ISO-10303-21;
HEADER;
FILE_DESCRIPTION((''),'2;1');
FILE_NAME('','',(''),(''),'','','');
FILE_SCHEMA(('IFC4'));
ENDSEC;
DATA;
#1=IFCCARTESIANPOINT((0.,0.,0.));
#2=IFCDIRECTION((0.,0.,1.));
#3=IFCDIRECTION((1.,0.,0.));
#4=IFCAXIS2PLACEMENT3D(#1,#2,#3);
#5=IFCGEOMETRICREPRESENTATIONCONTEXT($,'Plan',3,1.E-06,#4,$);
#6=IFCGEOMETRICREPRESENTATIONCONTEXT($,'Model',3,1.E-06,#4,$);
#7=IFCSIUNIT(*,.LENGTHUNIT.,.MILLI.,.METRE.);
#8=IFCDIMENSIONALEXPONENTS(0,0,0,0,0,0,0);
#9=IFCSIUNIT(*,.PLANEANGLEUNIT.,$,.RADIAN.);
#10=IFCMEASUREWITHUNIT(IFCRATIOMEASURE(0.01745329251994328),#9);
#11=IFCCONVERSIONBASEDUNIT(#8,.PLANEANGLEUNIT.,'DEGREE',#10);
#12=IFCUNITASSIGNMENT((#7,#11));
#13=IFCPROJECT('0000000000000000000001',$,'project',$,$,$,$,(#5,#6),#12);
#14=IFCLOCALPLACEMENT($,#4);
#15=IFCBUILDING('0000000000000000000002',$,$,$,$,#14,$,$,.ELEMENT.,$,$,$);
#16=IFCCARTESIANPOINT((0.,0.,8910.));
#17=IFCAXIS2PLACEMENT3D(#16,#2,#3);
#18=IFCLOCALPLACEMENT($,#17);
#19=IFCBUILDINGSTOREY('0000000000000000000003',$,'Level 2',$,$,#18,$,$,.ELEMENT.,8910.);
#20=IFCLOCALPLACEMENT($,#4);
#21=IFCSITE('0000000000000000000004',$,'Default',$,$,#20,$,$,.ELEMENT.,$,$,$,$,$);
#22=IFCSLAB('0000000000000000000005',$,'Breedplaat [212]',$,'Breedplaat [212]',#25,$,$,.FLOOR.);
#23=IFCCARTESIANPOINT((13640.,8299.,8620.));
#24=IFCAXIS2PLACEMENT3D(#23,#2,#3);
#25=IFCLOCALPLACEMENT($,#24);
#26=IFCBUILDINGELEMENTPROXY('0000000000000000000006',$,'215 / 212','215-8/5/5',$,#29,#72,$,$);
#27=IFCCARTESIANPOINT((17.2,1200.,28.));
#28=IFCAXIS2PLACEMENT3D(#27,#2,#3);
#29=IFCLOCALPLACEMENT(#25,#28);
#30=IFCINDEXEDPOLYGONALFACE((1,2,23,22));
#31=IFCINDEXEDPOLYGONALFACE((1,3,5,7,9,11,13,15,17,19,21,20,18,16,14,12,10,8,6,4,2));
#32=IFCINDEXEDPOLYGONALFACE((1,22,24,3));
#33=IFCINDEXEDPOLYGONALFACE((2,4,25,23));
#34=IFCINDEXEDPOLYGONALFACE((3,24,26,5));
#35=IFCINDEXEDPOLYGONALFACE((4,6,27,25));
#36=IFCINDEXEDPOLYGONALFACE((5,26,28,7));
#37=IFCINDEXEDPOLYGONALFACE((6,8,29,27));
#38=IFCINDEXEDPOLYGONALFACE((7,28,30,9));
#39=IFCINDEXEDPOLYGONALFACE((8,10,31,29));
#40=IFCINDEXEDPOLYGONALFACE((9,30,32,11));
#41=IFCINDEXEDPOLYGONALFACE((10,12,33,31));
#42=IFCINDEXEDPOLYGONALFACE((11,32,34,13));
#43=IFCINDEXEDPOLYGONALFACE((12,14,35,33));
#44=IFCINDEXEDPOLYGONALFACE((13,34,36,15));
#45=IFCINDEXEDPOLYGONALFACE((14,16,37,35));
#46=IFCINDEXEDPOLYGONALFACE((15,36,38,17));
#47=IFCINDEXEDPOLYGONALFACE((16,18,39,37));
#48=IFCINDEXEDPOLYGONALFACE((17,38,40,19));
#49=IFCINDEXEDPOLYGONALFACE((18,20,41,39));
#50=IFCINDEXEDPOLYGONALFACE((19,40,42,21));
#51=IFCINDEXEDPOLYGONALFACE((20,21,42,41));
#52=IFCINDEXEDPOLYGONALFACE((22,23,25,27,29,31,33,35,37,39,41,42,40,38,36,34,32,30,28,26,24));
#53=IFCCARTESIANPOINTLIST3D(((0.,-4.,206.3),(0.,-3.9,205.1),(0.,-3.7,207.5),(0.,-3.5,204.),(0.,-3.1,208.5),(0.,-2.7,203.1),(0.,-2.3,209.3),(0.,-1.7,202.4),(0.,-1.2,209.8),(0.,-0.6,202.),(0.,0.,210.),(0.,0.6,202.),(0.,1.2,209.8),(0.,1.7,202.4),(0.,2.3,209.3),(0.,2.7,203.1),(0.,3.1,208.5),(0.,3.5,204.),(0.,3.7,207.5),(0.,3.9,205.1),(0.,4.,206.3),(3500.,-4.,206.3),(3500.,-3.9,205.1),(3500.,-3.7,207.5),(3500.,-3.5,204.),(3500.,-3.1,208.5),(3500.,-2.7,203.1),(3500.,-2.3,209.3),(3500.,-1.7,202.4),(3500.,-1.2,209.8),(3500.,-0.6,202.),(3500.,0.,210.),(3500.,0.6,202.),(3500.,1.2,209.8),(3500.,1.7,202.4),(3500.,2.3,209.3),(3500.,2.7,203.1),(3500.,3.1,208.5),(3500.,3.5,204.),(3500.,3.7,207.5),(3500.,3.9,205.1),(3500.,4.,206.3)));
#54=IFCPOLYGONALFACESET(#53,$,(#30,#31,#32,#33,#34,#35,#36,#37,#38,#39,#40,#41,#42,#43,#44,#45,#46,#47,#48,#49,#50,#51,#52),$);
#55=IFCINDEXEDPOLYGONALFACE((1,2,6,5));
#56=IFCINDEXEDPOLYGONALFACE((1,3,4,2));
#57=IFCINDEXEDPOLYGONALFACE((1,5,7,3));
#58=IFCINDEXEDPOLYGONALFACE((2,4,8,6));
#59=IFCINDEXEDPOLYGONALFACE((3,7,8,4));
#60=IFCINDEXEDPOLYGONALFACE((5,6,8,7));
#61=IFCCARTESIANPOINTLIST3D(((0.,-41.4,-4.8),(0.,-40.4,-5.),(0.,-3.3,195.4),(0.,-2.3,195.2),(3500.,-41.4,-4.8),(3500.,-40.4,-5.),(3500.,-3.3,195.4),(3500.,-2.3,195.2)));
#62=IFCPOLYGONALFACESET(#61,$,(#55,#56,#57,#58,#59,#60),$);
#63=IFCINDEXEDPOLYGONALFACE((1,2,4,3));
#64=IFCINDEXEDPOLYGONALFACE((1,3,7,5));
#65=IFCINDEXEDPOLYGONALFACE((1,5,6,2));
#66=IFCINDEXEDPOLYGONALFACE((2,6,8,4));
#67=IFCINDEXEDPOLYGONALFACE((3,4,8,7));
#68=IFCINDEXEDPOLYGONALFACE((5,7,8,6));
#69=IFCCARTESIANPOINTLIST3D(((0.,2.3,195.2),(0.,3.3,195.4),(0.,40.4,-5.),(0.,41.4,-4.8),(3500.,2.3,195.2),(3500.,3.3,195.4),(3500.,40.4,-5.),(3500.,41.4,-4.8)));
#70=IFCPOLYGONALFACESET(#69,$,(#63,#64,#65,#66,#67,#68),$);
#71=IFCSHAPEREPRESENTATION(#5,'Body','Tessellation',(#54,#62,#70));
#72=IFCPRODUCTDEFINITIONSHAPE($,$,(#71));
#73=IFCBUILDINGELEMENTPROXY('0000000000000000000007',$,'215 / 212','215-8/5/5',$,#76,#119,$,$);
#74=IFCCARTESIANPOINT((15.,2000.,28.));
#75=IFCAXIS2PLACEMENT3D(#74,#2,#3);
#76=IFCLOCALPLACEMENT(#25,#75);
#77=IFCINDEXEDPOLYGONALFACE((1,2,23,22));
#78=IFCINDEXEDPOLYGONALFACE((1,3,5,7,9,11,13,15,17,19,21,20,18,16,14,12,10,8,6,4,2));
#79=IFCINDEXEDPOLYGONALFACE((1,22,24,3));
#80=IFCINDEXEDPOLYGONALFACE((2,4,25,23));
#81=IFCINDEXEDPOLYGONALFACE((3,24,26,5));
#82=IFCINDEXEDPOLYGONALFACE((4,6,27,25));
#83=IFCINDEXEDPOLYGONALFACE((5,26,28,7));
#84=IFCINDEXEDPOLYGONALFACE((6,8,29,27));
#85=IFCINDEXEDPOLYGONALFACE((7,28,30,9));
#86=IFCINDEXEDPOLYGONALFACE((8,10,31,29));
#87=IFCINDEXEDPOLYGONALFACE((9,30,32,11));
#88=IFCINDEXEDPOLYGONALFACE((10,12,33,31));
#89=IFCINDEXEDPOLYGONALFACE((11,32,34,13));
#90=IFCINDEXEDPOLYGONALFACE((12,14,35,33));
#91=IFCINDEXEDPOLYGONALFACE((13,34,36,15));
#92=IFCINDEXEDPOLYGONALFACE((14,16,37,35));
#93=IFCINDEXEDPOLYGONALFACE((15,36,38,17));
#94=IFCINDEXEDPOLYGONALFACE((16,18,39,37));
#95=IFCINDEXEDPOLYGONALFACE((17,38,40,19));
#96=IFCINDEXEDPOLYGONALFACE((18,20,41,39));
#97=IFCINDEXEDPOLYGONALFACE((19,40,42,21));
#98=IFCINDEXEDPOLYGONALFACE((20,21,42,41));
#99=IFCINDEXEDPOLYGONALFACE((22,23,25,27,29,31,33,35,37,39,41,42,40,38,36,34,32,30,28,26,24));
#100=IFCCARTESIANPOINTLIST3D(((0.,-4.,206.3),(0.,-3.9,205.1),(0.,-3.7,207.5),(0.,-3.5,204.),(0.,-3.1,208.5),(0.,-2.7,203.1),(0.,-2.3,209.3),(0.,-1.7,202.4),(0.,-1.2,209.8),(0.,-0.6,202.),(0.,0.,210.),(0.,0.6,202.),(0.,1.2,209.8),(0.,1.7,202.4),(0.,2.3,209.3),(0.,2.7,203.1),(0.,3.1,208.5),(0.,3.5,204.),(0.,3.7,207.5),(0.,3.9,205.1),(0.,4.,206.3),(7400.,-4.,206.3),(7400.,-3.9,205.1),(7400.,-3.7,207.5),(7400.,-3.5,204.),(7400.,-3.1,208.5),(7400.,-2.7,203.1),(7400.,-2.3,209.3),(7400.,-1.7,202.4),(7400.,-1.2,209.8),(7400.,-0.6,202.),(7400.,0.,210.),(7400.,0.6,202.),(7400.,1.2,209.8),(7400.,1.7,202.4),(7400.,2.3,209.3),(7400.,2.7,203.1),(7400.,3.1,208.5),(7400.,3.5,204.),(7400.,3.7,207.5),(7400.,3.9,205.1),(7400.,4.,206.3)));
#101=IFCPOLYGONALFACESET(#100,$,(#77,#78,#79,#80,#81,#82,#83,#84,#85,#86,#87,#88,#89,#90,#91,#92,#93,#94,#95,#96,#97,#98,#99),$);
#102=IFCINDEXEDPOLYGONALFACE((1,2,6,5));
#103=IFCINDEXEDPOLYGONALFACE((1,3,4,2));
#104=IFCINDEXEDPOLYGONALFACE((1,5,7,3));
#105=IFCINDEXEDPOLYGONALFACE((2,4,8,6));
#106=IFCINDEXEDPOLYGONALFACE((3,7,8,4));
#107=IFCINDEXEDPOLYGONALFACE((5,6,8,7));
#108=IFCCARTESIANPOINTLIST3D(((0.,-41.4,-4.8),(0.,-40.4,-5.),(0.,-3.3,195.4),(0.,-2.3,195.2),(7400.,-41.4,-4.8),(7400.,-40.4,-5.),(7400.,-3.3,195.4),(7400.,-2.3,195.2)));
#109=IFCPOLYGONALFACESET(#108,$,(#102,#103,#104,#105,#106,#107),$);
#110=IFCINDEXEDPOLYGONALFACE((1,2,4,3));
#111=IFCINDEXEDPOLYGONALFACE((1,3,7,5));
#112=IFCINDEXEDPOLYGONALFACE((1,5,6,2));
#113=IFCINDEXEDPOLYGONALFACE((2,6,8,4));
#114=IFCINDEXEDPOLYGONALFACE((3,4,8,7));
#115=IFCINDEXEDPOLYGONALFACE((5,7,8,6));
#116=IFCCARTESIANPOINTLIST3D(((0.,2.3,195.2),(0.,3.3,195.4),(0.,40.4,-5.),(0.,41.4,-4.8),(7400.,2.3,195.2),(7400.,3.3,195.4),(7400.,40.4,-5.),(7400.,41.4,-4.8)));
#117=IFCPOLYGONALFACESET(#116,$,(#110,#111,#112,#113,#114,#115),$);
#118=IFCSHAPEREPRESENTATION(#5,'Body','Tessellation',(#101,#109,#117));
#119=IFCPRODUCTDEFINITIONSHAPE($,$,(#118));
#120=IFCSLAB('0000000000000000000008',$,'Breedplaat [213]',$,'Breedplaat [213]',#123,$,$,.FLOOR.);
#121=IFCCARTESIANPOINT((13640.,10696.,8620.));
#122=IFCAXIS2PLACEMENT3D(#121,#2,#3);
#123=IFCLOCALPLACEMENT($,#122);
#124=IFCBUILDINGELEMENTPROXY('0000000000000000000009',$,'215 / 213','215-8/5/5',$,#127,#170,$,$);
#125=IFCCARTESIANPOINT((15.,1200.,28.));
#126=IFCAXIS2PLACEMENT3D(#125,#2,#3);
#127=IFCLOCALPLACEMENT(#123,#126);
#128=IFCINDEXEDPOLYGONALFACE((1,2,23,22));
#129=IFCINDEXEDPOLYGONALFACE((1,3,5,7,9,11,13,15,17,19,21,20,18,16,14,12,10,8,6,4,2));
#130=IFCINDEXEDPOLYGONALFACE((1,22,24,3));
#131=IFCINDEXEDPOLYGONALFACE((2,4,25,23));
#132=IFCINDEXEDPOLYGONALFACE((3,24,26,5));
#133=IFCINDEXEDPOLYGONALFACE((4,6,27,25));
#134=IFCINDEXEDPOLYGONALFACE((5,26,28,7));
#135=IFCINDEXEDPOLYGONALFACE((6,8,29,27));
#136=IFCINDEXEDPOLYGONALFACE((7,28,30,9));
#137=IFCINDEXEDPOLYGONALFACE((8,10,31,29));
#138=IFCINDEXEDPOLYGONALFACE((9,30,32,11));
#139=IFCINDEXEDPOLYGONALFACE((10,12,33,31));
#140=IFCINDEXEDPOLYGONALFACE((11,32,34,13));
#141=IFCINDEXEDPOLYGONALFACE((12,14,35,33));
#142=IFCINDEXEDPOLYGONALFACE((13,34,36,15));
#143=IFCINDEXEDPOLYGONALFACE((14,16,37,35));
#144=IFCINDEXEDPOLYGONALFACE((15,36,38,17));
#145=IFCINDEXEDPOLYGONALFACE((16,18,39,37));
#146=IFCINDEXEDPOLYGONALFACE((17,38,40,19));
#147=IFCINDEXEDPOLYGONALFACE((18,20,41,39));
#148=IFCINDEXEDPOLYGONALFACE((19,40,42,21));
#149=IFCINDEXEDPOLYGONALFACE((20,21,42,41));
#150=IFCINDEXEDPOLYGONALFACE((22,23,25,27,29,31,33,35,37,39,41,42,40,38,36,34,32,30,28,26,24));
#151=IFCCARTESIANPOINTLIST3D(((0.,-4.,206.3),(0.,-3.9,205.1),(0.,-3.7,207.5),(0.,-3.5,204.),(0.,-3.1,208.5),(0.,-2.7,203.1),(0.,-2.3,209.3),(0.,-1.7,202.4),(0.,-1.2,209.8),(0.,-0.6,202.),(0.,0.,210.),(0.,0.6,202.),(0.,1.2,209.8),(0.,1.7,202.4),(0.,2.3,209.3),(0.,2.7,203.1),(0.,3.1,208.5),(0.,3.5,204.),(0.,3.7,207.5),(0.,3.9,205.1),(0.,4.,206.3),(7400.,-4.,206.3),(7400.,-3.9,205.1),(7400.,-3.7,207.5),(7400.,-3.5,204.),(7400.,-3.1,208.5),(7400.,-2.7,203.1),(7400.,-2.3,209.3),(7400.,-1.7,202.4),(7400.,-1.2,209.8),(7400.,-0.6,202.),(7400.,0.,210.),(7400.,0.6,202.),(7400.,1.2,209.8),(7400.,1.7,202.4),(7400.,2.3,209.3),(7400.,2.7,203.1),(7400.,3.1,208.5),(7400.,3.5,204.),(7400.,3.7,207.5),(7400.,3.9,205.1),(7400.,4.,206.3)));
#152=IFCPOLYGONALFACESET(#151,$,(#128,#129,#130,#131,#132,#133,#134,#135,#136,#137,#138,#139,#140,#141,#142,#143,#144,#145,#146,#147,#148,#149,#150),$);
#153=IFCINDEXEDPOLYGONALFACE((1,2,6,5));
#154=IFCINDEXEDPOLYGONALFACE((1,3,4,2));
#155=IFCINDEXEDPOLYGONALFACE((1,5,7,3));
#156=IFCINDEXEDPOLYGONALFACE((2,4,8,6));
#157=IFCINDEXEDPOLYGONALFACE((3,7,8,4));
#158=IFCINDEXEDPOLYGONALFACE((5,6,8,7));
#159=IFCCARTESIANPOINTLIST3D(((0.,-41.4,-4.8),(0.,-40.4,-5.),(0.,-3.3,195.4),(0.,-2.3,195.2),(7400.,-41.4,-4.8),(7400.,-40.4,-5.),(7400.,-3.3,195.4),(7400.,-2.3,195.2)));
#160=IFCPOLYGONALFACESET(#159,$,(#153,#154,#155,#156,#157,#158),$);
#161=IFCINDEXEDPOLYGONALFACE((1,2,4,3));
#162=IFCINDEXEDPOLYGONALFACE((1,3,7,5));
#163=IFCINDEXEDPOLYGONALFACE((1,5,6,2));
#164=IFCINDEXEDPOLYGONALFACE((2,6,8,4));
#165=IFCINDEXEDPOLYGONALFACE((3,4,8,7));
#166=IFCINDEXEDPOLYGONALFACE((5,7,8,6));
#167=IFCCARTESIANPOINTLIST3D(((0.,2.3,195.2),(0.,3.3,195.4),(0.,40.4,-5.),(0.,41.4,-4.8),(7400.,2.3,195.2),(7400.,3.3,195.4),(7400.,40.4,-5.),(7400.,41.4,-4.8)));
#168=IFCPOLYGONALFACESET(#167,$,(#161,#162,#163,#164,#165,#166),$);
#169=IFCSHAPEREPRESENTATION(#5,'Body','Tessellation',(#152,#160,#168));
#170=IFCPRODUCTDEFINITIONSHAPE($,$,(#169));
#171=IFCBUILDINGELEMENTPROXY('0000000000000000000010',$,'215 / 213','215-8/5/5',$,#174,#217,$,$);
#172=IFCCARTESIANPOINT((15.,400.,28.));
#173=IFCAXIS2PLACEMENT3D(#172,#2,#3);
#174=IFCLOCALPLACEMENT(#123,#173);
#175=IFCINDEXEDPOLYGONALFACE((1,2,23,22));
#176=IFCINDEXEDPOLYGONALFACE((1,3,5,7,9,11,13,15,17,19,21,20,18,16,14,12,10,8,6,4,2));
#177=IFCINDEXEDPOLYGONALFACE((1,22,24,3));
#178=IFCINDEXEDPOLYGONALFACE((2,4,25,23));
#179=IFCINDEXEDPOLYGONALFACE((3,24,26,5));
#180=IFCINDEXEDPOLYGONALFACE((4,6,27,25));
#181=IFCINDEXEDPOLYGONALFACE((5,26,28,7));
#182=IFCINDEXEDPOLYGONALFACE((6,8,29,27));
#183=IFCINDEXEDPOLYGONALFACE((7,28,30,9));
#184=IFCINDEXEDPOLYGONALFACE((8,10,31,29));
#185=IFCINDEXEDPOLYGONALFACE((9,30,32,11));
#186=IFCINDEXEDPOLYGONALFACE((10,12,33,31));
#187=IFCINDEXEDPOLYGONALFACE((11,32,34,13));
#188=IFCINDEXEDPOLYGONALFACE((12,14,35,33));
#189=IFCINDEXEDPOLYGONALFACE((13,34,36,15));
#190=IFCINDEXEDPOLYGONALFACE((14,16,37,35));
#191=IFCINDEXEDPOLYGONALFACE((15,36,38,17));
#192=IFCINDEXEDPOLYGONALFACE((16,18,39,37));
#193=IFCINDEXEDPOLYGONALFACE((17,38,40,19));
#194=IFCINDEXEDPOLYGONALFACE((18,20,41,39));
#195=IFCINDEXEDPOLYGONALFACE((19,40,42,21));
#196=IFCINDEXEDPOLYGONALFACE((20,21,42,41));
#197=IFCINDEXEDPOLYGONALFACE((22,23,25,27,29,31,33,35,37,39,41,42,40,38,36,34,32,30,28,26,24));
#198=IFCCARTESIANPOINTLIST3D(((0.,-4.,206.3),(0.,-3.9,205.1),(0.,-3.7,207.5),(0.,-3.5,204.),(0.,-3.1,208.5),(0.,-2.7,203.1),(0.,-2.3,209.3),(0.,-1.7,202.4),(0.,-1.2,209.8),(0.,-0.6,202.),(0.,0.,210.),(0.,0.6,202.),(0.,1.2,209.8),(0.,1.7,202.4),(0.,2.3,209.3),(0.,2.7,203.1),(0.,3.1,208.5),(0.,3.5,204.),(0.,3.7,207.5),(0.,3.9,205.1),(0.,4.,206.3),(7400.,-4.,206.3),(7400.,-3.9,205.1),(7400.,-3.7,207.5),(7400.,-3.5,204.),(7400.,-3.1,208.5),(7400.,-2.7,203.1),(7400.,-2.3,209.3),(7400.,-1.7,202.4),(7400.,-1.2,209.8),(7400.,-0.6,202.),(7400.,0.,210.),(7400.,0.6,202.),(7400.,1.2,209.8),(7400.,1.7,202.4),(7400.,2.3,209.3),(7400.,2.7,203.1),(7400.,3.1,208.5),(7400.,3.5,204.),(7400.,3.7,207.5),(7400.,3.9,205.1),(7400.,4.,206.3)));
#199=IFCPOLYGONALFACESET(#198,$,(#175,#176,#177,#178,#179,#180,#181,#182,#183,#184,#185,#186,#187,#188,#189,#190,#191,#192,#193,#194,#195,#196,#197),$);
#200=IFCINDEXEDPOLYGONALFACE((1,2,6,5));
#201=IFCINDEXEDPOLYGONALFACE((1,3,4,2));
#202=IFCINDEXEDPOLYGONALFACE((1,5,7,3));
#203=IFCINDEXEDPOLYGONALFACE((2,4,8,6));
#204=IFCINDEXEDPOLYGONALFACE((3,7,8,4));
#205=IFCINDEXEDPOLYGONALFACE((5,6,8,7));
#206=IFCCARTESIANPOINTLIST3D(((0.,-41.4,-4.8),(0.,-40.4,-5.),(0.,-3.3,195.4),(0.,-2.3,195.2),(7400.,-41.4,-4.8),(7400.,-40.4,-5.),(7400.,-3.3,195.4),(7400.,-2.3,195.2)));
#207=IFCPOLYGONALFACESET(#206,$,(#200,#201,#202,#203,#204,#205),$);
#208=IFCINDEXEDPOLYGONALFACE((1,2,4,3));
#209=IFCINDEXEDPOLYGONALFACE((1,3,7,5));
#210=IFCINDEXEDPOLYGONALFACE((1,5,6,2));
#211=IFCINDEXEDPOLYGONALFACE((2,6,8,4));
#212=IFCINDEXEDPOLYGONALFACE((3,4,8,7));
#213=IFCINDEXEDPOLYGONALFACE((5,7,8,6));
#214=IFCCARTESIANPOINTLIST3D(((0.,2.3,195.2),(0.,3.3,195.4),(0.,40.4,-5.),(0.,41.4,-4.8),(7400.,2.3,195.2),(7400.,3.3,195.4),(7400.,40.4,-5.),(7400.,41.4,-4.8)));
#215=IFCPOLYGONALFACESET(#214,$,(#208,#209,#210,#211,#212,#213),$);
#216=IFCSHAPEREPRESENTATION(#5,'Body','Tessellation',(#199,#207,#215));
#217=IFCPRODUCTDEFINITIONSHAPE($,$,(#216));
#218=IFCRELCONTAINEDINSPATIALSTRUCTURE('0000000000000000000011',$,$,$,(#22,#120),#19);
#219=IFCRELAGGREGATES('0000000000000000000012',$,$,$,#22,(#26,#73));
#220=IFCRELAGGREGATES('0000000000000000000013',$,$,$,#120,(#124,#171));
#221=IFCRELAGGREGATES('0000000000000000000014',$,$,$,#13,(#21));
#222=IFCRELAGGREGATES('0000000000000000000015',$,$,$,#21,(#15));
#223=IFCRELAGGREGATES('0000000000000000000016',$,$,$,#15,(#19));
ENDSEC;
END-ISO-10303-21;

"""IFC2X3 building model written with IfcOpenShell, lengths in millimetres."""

from ifc_helpers import new_model, entity, si_unit, converted_unit, frame, origin_with_axes, origin_2d_with_axis, place, context, project, spatial, rectangle, circle, extrude, element, aggregate, save


model = new_model("IFC2X3")

# Units and contexts
plan_context = context("Plan", 3, precision=1e-06, world=origin_with_axes())
model_context = context("Model", 3, precision=1e-06, world=origin_with_axes())
ifc_project = project(units=[si_unit("LENGTHUNIT", "METRE", prefix="MILLI"), converted_unit("PLANEANGLEUNIT", "DEGREE", entity("IfcRatioMeasure", 0.01745329251994328), si_unit("PLANEANGLEUNIT", "RADIAN"), dimensions=[0, 0, 0, 0, 0, 0, 0])], contexts=[plan_context, model_context])

# Site, building, storey
site_placement = place(None, origin_with_axes())
site = spatial("IfcSite", under=ifc_project, at=site_placement, Name="Default", CompositionType="ELEMENT")
building_placement = place(None, origin_with_axes())
building = spatial("IfcBuilding", under=site, at=building_placement, CompositionType="ELEMENT")
storey_placement = place(None, frame((0.0, 0.0, 8910.0), z_axis=(0.0, 0.0, 1.0), x_axis=(1.0, 0.0, 0.0)))
storey = spatial("IfcBuildingStorey", under=building, at=storey_placement, Name="Level 2", CompositionType="ELEMENT", Elevation=8910.0)

# Slab, building element proxies
slab_1_placement = place(None, frame((13640.0, 8299.0, 8620.0), z_axis=(0.0, 0.0, 1.0), x_axis=(1.0, 0.0, 0.0)))
slab_1 = element("IfcSlab", 1, at=slab_1_placement, inside=storey, Name="Breedplaat [212]", ObjectType="Breedplaat [212]", PredefinedType="FLOOR")
proxy_1_placement = place(slab_1_placement, frame((17.2, 1200.0, 28.0), z_axis=(0.0, 0.0, 1.0), x_axis=(1.0, 0.0, 0.0)))
proxy_1 = element("IfcBuildingElementProxy", 2, at=proxy_1_placement, Name="215 / 212", Description="215-8/5/5", context=plan_context, shape_type="SweptSolid", body=[
    extrude(circle(Radius=4.0, at=origin_2d_with_axis()), frame((0.0, 0.0, 206.0), z_axis=(1.0, 0.0, 0.0), x_axis=(0.0, 0.0, 1.0)), (0.0, 0.0, 1.0), 3500.0),
    extrude(rectangle(XDim=203.8, YDim=1.0, at=origin_2d_with_axis()), frame((0.0, -21.9, 95.2), z_axis=(1.0, 0.0, 0.0), x_axis=(0.0, 0.187112, 0.982339)), (0.0, 0.0, 1.0), 3500.0),
    extrude(rectangle(XDim=203.8, YDim=1.0, at=origin_2d_with_axis()), frame((0.0, 21.9, 95.2), z_axis=(1.0, 0.0, 0.0), x_axis=(0.0, -0.187112, 0.982339)), (0.0, 0.0, 1.0), 3500.0),
])
proxy_2_placement = place(slab_1_placement, frame((15.0, 2000.0, 28.0), z_axis=(0.0, 0.0, 1.0), x_axis=(1.0, 0.0, 0.0)))
proxy_2 = element("IfcBuildingElementProxy", 3, at=proxy_2_placement, Name="215 / 212", Description="215-8/5/5", context=plan_context, shape_type="SweptSolid", body=[
    extrude(circle(Radius=4.0, at=origin_2d_with_axis()), frame((0.0, 0.0, 206.0), z_axis=(1.0, 0.0, 0.0), x_axis=(0.0, 0.0, 1.0)), (0.0, 0.0, 1.0), 7400.0),
    extrude(rectangle(XDim=203.8, YDim=1.0, at=origin_2d_with_axis()), frame((0.0, -21.9, 95.2), z_axis=(1.0, 0.0, 0.0), x_axis=(0.0, 0.187112, 0.982339)), (0.0, 0.0, 1.0), 7400.0),
    extrude(rectangle(XDim=203.8, YDim=1.0, at=origin_2d_with_axis()), frame((0.0, 21.9, 95.2), z_axis=(1.0, 0.0, 0.0), x_axis=(0.0, -0.187112, 0.982339)), (0.0, 0.0, 1.0), 7400.0),
])
aggregate(slab_1, [proxy_1, proxy_2])

# Slab, building element proxies
slab_2_placement = place(None, frame((13640.0, 10696.0, 8620.0), z_axis=(0.0, 0.0, 1.0), x_axis=(1.0, 0.0, 0.0)))
slab_2 = element("IfcSlab", 4, at=slab_2_placement, inside=storey, Name="Breedplaat [213]", ObjectType="Breedplaat [213]", PredefinedType="FLOOR")
proxy_3_placement = place(slab_2_placement, frame((15.0, 1200.0, 28.0), z_axis=(0.0, 0.0, 1.0), x_axis=(1.0, 0.0, 0.0)))
proxy_3 = element("IfcBuildingElementProxy", 5, at=proxy_3_placement, Name="215 / 213", Description="215-8/5/5", context=plan_context, shape_type="SweptSolid", body=[
    extrude(circle(Radius=4.0, at=origin_2d_with_axis()), frame((0.0, 0.0, 206.0), z_axis=(1.0, 0.0, 0.0), x_axis=(0.0, 0.0, 1.0)), (0.0, 0.0, 1.0), 7400.0),
    extrude(rectangle(XDim=203.8, YDim=1.0, at=origin_2d_with_axis()), frame((0.0, -21.9, 95.2), z_axis=(1.0, 0.0, 0.0), x_axis=(0.0, 0.187112, 0.982339)), (0.0, 0.0, 1.0), 7400.0),
    extrude(rectangle(XDim=203.8, YDim=1.0, at=origin_2d_with_axis()), frame((0.0, 21.9, 95.2), z_axis=(1.0, 0.0, 0.0), x_axis=(0.0, -0.187112, 0.982339)), (0.0, 0.0, 1.0), 7400.0),
])
proxy_4_placement = place(slab_2_placement, frame((15.0, 400.0, 28.0), z_axis=(0.0, 0.0, 1.0), x_axis=(1.0, 0.0, 0.0)))
proxy_4 = element("IfcBuildingElementProxy", 6, at=proxy_4_placement, Name="215 / 213", Description="215-8/5/5", context=plan_context, shape_type="SweptSolid", body=[
    extrude(circle(Radius=4.0, at=origin_2d_with_axis()), frame((0.0, 0.0, 206.0), z_axis=(1.0, 0.0, 0.0), x_axis=(0.0, 0.0, 1.0)), (0.0, 0.0, 1.0), 7400.0),
    extrude(rectangle(XDim=203.8, YDim=1.0, at=origin_2d_with_axis()), frame((0.0, -21.9, 95.2), z_axis=(1.0, 0.0, 0.0), x_axis=(0.0, 0.187112, 0.982339)), (0.0, 0.0, 1.0), 7400.0),
    extrude(rectangle(XDim=203.8, YDim=1.0, at=origin_2d_with_axis()), frame((0.0, 21.9, 95.2), z_axis=(1.0, 0.0, 0.0), x_axis=(0.0, -0.187112, 0.982339)), (0.0, 0.0, 1.0), 7400.0),
])
aggregate(slab_2, [proxy_3, proxy_4])

save(model, "model.ifc")
